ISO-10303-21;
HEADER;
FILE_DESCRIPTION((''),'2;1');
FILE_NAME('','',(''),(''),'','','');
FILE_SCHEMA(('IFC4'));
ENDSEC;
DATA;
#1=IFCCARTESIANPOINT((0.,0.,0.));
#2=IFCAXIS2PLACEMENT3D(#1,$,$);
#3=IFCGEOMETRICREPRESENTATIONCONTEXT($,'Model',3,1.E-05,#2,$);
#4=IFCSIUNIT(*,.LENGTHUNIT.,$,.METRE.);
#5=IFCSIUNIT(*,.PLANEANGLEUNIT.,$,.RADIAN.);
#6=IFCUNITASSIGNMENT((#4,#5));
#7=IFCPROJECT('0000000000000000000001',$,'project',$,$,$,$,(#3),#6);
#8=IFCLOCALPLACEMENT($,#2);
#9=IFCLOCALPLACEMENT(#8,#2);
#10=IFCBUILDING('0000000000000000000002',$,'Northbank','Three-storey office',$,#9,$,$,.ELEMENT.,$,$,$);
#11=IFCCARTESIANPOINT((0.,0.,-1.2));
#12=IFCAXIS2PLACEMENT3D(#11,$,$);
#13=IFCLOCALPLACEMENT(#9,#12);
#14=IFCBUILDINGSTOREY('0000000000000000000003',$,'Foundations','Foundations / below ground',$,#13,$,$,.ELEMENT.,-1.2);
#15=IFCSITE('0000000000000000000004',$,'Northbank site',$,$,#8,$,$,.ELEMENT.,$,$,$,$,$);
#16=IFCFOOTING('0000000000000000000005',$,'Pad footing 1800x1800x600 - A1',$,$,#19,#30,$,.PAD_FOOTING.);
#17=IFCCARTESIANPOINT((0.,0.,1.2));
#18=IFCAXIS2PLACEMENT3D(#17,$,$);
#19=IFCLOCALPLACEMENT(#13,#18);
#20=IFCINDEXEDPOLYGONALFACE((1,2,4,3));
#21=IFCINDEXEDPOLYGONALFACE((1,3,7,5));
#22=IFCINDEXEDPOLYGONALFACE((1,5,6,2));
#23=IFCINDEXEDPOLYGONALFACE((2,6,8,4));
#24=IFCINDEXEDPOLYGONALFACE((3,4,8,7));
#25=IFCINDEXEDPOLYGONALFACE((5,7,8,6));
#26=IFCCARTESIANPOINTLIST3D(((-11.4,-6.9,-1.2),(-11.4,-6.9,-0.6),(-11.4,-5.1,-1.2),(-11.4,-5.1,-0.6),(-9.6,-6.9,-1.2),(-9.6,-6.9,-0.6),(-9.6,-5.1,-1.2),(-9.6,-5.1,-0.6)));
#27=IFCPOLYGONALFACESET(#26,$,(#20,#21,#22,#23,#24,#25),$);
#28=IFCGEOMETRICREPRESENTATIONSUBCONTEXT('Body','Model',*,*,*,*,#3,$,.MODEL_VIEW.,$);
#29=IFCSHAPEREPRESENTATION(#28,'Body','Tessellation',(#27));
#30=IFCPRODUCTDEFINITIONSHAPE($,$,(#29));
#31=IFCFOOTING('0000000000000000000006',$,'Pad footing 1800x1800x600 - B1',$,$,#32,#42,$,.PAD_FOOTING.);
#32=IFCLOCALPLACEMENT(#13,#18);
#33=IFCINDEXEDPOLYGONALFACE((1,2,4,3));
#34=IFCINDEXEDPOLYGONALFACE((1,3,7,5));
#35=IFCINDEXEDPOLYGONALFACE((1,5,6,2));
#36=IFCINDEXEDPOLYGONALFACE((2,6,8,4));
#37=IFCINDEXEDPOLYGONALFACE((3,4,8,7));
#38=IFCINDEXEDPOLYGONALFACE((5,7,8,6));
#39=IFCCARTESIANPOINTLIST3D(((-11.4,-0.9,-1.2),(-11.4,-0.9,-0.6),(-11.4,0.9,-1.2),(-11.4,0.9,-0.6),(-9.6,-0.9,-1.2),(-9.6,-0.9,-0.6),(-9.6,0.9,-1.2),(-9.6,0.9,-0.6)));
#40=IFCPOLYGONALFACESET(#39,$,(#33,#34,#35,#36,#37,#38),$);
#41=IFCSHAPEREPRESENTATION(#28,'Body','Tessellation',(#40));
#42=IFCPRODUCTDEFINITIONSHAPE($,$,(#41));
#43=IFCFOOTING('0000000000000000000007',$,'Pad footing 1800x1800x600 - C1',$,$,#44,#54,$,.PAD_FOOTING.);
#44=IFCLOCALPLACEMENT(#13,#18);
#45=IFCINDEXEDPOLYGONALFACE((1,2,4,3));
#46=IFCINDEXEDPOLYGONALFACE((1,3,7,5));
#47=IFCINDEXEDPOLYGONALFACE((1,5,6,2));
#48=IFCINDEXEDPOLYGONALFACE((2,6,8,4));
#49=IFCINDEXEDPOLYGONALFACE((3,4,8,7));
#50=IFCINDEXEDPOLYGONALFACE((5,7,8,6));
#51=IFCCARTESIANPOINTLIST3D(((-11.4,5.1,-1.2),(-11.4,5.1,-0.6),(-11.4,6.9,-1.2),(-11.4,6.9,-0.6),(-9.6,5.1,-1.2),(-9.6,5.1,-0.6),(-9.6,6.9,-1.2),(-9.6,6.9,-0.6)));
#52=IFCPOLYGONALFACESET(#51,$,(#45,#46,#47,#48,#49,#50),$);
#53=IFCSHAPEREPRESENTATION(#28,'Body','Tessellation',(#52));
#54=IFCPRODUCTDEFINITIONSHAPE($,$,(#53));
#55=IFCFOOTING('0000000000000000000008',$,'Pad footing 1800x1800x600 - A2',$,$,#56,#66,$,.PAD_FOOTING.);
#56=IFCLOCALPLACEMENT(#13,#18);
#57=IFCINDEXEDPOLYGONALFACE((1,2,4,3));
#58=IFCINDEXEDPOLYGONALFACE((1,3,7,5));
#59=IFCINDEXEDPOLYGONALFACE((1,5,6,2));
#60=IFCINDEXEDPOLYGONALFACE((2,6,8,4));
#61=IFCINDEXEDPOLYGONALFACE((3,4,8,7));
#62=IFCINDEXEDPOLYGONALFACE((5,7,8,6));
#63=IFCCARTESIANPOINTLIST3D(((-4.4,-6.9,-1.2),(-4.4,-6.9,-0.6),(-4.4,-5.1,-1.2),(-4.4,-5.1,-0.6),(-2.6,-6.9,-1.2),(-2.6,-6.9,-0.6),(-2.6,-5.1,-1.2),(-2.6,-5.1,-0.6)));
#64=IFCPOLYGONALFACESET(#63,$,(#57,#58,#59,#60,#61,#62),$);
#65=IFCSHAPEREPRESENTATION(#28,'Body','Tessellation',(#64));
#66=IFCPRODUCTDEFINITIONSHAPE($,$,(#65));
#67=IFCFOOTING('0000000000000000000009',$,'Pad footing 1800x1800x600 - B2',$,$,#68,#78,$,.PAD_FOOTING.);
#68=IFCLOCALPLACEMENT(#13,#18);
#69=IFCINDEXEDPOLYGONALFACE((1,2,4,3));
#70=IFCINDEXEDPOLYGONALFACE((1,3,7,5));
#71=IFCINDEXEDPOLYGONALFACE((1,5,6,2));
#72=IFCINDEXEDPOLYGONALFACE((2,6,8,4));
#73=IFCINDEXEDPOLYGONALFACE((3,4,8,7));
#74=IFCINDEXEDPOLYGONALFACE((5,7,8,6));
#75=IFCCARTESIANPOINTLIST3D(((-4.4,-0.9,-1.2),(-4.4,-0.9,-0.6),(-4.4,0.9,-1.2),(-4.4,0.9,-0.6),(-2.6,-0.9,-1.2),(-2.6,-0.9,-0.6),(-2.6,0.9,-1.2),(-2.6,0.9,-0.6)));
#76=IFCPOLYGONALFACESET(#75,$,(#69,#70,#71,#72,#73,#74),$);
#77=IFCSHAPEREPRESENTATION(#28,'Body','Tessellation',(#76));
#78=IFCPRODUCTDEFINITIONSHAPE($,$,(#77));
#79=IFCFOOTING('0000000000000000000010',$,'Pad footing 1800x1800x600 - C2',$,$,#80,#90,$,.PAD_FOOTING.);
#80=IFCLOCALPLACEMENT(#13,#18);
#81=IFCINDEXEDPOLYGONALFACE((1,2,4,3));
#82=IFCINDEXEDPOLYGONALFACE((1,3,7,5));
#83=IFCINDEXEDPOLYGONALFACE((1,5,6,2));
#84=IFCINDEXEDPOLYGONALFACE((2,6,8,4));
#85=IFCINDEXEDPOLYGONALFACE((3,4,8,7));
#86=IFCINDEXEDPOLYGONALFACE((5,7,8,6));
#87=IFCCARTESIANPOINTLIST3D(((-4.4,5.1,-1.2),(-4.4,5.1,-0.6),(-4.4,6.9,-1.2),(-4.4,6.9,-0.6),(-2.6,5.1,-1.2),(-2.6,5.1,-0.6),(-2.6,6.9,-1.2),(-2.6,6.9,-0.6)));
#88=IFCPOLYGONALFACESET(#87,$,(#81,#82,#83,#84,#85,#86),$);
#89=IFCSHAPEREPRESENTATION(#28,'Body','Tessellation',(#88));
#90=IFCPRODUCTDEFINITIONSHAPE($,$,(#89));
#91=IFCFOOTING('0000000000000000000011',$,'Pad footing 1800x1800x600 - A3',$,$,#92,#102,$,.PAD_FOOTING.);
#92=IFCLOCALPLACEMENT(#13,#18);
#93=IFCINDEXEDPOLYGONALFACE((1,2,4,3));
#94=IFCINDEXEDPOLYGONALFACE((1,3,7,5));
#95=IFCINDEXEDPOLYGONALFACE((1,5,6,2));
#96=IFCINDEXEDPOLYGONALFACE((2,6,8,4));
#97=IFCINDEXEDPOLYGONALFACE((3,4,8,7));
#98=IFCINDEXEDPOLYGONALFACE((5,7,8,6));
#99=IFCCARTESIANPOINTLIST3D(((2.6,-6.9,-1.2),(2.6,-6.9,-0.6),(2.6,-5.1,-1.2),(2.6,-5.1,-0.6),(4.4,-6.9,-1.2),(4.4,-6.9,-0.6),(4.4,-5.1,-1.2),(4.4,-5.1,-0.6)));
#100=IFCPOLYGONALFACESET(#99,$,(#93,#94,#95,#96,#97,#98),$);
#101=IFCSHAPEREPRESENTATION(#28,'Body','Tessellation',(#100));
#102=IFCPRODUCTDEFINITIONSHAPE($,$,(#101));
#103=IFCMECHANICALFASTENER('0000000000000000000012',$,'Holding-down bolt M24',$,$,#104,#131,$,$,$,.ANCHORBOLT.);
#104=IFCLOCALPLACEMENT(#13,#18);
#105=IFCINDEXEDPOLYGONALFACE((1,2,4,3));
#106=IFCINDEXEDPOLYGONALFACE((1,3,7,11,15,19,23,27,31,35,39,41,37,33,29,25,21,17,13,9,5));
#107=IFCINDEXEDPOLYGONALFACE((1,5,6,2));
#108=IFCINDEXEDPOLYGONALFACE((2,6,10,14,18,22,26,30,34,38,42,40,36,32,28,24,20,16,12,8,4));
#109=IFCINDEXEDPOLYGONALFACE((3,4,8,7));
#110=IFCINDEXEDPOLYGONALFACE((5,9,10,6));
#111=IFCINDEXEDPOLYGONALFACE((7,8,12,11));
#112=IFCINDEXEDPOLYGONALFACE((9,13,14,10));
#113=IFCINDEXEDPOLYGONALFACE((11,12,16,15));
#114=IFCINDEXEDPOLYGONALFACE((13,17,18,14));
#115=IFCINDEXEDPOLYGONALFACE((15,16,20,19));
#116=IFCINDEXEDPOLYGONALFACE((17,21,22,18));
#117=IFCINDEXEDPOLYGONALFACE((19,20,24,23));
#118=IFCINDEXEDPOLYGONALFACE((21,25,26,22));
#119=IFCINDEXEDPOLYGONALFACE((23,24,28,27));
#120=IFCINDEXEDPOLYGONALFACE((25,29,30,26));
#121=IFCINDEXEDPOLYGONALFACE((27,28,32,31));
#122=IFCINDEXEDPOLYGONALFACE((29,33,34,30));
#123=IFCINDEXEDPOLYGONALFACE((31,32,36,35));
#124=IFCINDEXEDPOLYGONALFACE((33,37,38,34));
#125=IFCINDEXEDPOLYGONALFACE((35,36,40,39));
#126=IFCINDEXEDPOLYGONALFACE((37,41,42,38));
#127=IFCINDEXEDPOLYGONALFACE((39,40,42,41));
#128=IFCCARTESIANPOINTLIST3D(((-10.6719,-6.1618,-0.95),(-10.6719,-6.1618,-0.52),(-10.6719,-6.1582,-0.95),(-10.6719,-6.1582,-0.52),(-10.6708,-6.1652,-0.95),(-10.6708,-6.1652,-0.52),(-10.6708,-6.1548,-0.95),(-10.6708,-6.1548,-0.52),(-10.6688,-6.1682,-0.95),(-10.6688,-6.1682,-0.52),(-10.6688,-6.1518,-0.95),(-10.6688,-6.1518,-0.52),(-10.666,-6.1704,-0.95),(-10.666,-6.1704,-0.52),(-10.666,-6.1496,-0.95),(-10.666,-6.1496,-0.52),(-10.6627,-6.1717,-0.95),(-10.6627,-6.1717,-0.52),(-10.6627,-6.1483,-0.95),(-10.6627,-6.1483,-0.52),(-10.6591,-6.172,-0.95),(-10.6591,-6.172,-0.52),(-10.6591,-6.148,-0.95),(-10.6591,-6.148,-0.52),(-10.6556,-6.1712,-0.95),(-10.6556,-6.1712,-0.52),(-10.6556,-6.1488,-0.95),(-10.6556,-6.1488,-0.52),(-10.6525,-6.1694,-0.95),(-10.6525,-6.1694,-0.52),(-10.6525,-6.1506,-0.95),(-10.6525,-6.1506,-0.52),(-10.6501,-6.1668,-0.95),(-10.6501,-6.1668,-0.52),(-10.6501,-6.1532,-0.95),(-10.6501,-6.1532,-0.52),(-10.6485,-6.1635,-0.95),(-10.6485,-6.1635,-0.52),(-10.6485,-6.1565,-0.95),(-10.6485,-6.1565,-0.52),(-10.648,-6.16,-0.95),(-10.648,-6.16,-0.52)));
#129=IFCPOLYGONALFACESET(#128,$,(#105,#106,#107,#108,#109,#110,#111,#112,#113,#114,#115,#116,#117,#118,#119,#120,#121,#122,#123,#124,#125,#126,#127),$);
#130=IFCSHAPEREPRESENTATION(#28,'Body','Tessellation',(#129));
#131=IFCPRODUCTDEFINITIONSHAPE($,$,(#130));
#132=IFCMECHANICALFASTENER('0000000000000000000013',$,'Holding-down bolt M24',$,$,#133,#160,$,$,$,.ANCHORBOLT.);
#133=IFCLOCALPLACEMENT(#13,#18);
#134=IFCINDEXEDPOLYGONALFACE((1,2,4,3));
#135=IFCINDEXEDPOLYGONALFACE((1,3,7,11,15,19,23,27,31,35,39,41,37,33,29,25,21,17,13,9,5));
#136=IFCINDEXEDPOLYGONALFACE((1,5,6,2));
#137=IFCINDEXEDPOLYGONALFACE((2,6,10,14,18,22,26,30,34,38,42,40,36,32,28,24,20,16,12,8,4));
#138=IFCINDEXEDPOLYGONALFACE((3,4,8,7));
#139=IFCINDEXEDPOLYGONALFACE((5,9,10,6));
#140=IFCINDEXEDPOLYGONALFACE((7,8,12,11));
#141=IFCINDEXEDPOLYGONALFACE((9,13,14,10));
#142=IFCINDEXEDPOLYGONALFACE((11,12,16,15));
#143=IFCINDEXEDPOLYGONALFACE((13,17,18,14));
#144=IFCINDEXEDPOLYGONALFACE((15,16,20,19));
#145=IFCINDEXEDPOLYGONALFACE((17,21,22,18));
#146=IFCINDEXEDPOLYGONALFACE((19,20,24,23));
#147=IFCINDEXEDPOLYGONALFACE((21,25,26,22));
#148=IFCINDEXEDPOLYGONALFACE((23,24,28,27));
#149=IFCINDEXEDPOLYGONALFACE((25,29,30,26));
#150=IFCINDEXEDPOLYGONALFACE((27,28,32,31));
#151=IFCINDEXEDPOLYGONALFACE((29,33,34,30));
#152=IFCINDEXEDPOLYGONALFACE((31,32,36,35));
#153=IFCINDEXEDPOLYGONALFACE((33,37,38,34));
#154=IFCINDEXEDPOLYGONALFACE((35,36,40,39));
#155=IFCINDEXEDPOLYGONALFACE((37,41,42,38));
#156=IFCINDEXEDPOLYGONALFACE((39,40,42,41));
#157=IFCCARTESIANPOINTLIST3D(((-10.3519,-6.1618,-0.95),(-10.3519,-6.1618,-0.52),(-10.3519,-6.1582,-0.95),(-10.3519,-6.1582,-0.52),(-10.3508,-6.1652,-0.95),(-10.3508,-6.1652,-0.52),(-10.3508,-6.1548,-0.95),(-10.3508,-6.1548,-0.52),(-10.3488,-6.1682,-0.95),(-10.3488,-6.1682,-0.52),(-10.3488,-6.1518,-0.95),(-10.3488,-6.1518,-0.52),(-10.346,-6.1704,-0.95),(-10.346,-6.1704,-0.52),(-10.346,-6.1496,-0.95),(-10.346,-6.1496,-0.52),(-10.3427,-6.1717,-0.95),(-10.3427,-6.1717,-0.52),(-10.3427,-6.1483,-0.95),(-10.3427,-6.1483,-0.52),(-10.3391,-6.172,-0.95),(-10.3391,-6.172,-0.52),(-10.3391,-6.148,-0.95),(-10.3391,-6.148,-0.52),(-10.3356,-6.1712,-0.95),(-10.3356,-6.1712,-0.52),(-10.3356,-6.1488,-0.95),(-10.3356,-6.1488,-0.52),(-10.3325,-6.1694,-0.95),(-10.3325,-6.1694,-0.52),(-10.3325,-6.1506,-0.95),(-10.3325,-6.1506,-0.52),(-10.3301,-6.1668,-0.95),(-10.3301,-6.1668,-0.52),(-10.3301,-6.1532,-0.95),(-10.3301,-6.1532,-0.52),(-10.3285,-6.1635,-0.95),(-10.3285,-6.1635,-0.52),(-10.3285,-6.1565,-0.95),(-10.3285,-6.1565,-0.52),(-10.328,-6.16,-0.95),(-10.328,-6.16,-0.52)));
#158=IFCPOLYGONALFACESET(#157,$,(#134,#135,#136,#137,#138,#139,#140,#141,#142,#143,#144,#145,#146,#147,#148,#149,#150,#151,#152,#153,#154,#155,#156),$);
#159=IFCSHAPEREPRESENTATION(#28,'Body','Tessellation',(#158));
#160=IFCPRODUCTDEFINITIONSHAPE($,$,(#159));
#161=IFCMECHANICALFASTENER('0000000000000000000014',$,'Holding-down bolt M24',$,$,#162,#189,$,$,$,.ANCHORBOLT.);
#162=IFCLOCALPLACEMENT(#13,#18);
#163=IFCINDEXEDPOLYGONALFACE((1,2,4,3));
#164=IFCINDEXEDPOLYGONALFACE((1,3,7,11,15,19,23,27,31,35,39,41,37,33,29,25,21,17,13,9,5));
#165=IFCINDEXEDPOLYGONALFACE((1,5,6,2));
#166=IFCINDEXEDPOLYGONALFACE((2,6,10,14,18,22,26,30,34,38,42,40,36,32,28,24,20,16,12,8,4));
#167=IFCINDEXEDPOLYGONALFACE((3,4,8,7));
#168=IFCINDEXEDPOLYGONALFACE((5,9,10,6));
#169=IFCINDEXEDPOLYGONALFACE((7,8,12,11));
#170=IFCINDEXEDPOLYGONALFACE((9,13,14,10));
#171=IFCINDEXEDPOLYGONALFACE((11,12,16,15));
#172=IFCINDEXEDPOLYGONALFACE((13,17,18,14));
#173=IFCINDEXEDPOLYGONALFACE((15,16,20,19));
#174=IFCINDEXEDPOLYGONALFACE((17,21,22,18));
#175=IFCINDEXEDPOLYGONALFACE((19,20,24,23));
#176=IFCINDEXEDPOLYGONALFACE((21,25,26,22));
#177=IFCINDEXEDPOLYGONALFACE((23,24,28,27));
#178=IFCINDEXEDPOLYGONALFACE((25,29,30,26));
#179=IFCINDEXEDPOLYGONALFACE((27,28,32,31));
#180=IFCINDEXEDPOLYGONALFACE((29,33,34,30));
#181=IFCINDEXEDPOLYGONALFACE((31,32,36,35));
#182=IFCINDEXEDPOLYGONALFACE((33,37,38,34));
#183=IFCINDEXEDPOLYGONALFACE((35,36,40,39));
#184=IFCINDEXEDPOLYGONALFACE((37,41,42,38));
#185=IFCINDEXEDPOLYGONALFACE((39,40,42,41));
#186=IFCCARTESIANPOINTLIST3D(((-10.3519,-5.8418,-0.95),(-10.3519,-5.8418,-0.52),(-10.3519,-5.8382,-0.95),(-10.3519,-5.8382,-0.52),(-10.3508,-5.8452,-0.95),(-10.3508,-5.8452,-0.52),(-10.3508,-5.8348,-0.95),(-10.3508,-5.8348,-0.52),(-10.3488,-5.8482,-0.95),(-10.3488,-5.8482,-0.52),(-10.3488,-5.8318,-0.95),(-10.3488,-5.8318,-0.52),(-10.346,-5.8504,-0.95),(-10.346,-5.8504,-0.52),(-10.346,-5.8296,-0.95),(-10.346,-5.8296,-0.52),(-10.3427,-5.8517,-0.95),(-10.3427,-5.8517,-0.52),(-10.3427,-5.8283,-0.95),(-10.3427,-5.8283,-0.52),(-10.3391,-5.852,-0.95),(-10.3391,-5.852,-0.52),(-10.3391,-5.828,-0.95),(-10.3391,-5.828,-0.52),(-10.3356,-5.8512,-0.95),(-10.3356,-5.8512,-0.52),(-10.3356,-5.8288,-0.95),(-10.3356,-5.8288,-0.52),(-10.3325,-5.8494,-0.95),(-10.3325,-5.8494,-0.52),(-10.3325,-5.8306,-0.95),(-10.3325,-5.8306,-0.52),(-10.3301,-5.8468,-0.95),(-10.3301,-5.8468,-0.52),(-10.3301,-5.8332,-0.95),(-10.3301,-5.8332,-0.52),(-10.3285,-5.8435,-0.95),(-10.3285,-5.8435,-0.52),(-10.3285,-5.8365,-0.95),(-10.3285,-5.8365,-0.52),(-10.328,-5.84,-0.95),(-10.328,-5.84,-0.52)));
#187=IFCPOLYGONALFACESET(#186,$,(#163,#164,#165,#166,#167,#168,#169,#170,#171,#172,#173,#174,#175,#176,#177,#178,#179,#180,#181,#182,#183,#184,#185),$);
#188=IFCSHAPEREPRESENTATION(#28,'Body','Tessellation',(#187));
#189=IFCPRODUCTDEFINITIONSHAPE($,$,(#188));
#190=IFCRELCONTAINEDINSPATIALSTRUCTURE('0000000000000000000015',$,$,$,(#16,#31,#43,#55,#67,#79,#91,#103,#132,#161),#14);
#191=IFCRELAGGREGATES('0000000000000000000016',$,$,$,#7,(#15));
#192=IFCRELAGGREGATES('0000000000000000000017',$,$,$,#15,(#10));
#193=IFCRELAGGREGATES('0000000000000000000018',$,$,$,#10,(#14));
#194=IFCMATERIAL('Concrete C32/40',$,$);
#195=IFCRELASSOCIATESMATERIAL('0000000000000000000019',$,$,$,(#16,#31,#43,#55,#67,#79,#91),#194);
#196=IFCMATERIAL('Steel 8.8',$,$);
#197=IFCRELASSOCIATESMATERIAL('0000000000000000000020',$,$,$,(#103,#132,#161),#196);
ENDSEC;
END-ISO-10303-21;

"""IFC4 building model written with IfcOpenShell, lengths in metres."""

from ifc_helpers import new_model, si_unit, frame, origin, place, context, subcontext, project, spatial, rectangle, circle, extrude, material, element, save


model = new_model("IFC4")

# Units and contexts
model_context = context("Model", 3, precision=1e-05, world=origin())
body_context = subcontext(model_context, "Body", "Model", "MODEL_VIEW")
ifc_project = project(units=[si_unit("LENGTHUNIT", "METRE"), si_unit("PLANEANGLEUNIT", "RADIAN")], contexts=[model_context])

# Site, building, storey
site_placement = place(None, origin())
site = spatial("IfcSite", under=ifc_project, at=site_placement, Name="Northbank site", CompositionType="ELEMENT")
building_placement = place(site_placement, origin())
building = spatial("IfcBuilding", under=site, at=building_placement, Name="Northbank", Description="Three-storey office", CompositionType="ELEMENT")
storey_placement = place(building_placement, frame((0.0, 0.0, -1.2)))
storey = spatial("IfcBuildingStorey", under=building, at=storey_placement, Name="Foundations", Description="Foundations / below ground", CompositionType="ELEMENT", Elevation=-1.2)

# Footings
ifc_material_1 = material(Name="Concrete C32/40")
footing_1_placement = place(storey_placement, frame((0.0, 0.0, 1.2)))
element("IfcFooting", 1, at=footing_1_placement, inside=storey, material=ifc_material_1, Name="Pad footing 1800x1800x600 - A1", PredefinedType="PAD_FOOTING", context=body_context, shape_type="SweptSolid", body=[
    extrude(rectangle(XDim=1.8, YDim=1.8), frame((-10.5, -6.0, -1.2)), (0.0, 0.0, 1.0), 0.6),
])
footing_2_placement = place(storey_placement, frame((0.0, 0.0, 1.2)))
element("IfcFooting", 2, at=footing_2_placement, inside=storey, material=ifc_material_1, Name="Pad footing 1800x1800x600 - B1", PredefinedType="PAD_FOOTING", context=body_context, shape_type="SweptSolid", body=[
    extrude(rectangle(XDim=1.8, YDim=1.8), frame((-10.5, 0.0, -1.2)), (0.0, 0.0, 1.0), 0.6),
])
footing_3_placement = place(storey_placement, frame((0.0, 0.0, 1.2)))
element("IfcFooting", 3, at=footing_3_placement, inside=storey, material=ifc_material_1, Name="Pad footing 1800x1800x600 - C1", PredefinedType="PAD_FOOTING", context=body_context, shape_type="SweptSolid", body=[
    extrude(rectangle(XDim=1.8, YDim=1.8), frame((-10.5, 6.0, -1.2)), (0.0, 0.0, 1.0), 0.6),
])
footing_4_placement = place(storey_placement, frame((0.0, 0.0, 1.2)))
element("IfcFooting", 4, at=footing_4_placement, inside=storey, material=ifc_material_1, Name="Pad footing 1800x1800x600 - A2", PredefinedType="PAD_FOOTING", context=body_context, shape_type="SweptSolid", body=[
    extrude(rectangle(XDim=1.8, YDim=1.8), frame((-3.5, -6.0, -1.2)), (0.0, 0.0, 1.0), 0.6),
])
footing_5_placement = place(storey_placement, frame((0.0, 0.0, 1.2)))
element("IfcFooting", 5, at=footing_5_placement, inside=storey, material=ifc_material_1, Name="Pad footing 1800x1800x600 - B2", PredefinedType="PAD_FOOTING", context=body_context, shape_type="SweptSolid", body=[
    extrude(rectangle(XDim=1.8, YDim=1.8), frame((-3.5, 0.0, -1.2)), (0.0, 0.0, 1.0), 0.6),
])
footing_6_placement = place(storey_placement, frame((0.0, 0.0, 1.2)))
element("IfcFooting", 6, at=footing_6_placement, inside=storey, material=ifc_material_1, Name="Pad footing 1800x1800x600 - C2", PredefinedType="PAD_FOOTING", context=body_context, shape_type="SweptSolid", body=[
    extrude(rectangle(XDim=1.8, YDim=1.8), frame((-3.5, 6.0, -1.2)), (0.0, 0.0, 1.0), 0.6),
])
footing_7_placement = place(storey_placement, frame((0.0, 0.0, 1.2)))
element("IfcFooting", 7, at=footing_7_placement, inside=storey, material=ifc_material_1, Name="Pad footing 1800x1800x600 - A3", PredefinedType="PAD_FOOTING", context=body_context, shape_type="SweptSolid", body=[
    extrude(rectangle(XDim=1.8, YDim=1.8), frame((3.5, -6.0, -1.2)), (0.0, 0.0, 1.0), 0.6),
])

# Mechanical fasteners
ifc_material_2 = material(Name="Steel 8.8")
mechanical_fastener_1_placement = place(storey_placement, frame((0.0, 0.0, 1.2)))
element("IfcMechanicalFastener", 8, at=mechanical_fastener_1_placement, inside=storey, material=ifc_material_2, Name="Holding-down bolt M24", PredefinedType="ANCHORBOLT", context=body_context, shape_type="SweptSolid", body=[
    extrude(circle(Radius=0.012), frame((-10.66, -6.16, -0.95), z_axis=(0.0, 0.0, 1.0), x_axis=(1.0, 0.0, 0.0)), (0.0, 0.0, 1.0), 0.43),
])
mechanical_fastener_2_placement = place(storey_placement, frame((0.0, 0.0, 1.2)))
element("IfcMechanicalFastener", 9, at=mechanical_fastener_2_placement, inside=storey, material=ifc_material_2, Name="Holding-down bolt M24", PredefinedType="ANCHORBOLT", context=body_context, shape_type="SweptSolid", body=[
    extrude(circle(Radius=0.012), frame((-10.34, -6.16, -0.95), z_axis=(0.0, 0.0, 1.0), x_axis=(1.0, 0.0, 0.0)), (0.0, 0.0, 1.0), 0.43),
])
mechanical_fastener_3_placement = place(storey_placement, frame((0.0, 0.0, 1.2)))
element("IfcMechanicalFastener", 10, at=mechanical_fastener_3_placement, inside=storey, material=ifc_material_2, Name="Holding-down bolt M24", PredefinedType="ANCHORBOLT", context=body_context, shape_type="SweptSolid", body=[
    extrude(circle(Radius=0.012), frame((-10.34, -5.84, -0.95), z_axis=(0.0, 0.0, 1.0), x_axis=(1.0, 0.0, 0.0)), (0.0, 0.0, 1.0), 0.43),
])

save(model, "model.ifc")
